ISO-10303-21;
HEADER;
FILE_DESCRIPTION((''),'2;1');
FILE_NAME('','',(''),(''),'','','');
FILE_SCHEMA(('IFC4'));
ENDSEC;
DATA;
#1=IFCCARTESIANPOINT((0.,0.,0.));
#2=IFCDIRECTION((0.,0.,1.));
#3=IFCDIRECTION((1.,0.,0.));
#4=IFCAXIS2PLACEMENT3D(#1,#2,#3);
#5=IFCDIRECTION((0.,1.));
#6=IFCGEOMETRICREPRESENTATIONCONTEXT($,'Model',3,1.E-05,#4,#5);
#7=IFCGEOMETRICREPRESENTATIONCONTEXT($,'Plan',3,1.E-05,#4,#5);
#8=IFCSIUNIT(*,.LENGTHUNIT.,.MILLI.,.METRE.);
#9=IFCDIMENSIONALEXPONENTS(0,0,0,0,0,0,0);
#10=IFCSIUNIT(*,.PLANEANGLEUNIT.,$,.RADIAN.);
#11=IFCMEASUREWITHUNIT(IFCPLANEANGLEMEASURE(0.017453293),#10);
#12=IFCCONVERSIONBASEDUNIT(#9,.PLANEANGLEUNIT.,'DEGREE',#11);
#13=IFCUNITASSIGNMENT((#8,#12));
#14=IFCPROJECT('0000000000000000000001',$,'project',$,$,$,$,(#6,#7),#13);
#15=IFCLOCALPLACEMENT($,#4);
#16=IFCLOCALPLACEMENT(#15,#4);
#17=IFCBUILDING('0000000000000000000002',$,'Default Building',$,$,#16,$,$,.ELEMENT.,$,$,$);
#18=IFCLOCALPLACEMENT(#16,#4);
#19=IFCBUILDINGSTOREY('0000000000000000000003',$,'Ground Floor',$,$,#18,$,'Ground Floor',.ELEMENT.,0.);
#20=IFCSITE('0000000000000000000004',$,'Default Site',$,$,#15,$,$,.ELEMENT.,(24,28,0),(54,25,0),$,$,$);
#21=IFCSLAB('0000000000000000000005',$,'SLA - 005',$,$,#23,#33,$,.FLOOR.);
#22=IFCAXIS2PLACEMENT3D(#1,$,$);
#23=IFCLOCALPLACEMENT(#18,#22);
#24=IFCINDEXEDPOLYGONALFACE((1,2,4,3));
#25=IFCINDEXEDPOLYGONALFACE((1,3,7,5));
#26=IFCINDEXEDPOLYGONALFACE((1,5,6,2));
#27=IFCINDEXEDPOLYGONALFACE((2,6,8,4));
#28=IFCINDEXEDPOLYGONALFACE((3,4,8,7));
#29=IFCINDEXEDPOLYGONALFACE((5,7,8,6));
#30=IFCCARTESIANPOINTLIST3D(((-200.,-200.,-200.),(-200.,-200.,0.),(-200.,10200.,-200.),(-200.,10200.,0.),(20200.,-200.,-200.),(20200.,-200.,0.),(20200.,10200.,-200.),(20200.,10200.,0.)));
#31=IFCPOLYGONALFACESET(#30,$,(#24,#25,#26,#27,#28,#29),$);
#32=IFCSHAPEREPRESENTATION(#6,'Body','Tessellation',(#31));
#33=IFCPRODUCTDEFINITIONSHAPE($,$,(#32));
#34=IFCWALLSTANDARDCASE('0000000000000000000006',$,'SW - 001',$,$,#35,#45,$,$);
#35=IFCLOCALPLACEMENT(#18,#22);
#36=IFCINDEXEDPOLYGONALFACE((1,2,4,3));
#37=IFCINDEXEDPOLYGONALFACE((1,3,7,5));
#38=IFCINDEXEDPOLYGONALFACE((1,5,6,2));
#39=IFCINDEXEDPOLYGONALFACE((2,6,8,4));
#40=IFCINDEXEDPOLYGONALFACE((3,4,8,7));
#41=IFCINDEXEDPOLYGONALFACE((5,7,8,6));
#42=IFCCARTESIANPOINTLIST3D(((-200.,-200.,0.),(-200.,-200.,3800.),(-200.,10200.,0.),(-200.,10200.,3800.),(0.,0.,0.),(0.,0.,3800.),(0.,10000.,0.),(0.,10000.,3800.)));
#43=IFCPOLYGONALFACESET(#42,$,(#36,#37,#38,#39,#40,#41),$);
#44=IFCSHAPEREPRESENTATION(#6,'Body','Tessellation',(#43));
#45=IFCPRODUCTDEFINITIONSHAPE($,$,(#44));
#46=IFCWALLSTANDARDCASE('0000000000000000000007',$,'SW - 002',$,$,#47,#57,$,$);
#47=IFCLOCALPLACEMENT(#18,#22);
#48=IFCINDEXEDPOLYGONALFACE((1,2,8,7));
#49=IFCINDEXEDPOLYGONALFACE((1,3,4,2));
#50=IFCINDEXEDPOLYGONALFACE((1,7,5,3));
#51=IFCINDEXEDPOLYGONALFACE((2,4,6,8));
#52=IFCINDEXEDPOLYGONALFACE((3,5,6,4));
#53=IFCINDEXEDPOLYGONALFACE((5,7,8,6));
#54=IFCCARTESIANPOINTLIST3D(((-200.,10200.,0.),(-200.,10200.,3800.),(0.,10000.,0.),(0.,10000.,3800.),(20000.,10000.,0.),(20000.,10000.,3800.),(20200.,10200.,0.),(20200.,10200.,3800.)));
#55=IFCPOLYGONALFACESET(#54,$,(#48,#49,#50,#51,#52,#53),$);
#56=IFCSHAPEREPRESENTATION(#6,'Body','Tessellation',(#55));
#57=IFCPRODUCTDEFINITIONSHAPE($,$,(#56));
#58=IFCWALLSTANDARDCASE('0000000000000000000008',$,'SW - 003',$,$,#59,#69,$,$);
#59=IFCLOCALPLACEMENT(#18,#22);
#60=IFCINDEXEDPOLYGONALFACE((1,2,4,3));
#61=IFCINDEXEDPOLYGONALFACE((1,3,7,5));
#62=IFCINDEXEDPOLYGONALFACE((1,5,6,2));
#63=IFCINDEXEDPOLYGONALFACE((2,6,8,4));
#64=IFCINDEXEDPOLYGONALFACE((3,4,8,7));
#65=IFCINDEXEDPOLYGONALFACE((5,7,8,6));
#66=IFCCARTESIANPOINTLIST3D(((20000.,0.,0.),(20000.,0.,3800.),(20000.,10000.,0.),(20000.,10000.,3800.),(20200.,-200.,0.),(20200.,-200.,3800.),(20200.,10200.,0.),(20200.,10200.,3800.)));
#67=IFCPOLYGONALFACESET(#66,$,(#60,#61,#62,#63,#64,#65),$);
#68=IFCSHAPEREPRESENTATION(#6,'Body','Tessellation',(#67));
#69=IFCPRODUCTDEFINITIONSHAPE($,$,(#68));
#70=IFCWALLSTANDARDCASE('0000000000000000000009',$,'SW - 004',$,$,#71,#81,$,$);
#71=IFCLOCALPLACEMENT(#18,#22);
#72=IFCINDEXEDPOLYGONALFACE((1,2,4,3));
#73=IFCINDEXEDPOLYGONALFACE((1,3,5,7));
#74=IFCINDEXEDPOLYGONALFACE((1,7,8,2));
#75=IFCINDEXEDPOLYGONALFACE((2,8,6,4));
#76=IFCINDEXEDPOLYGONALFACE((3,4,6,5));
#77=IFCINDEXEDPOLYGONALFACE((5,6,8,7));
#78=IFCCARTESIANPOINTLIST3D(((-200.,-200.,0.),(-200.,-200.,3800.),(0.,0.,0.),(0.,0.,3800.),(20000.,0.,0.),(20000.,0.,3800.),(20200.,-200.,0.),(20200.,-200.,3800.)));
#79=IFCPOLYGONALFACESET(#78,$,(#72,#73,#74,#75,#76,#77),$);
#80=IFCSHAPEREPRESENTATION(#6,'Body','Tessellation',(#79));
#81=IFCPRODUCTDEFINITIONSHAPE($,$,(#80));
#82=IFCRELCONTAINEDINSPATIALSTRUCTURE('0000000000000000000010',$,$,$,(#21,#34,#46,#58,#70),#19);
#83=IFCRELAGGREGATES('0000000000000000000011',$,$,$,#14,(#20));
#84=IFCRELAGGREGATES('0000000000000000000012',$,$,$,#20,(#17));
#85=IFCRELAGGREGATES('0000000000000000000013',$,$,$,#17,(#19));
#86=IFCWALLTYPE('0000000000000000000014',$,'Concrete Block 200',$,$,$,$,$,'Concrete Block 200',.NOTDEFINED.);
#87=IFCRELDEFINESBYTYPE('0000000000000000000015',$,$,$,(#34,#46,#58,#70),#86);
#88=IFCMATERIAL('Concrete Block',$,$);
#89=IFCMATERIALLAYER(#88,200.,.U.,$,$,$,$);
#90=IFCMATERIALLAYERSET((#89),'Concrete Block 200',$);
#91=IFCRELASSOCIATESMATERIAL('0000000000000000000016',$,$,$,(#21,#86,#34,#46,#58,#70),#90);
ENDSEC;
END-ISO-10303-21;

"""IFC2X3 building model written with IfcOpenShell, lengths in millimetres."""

from ifc_helpers import new_model, entity, si_unit, converted_unit, direction, frame, origin_with_axes, place, context, project, spatial, polyline, outline, extrude, material, layer, layer_set, layer_usage, type_object, element, save


model = new_model("IFC2X3")

# Units and contexts
model_context = context("Model", 3, precision=1e-05, world=origin_with_axes(), true_north=direction((0.0, 1.0)))
plan_context = context("Plan", 3, precision=1e-05, world=origin_with_axes(), true_north=direction((0.0, 1.0)))
ifc_project = project(units=[si_unit("LENGTHUNIT", "METRE", prefix="MILLI"), converted_unit("PLANEANGLEUNIT", "DEGREE", entity("IfcPlaneAngleMeasure", 0.017453293), si_unit("PLANEANGLEUNIT", "RADIAN"), dimensions=[0, 0, 0, 0, 0, 0, 0])], contexts=[model_context, plan_context])

# Site, building, storey
site_placement = place(None, origin_with_axes())
site = spatial("IfcSite", under=ifc_project, at=site_placement, Name="Default Site", CompositionType="ELEMENT", RefLatitude=(24, 28, 0), RefLongitude=(54, 25, 0))
building_placement = place(site_placement, origin_with_axes())
building = spatial("IfcBuilding", under=site, at=building_placement, Name="Default Building", CompositionType="ELEMENT")
storey_placement = place(building_placement, origin_with_axes())
storey = spatial("IfcBuildingStorey", under=building, at=storey_placement, Name="Ground Floor", LongName="Ground Floor", CompositionType="ELEMENT", Elevation=0.0)

# Slab
ifc_material = material(Name="Concrete Block")
ifc_layer = layer(ifc_material, 200.0, ventilated="UNKNOWN")
ifc_layer_set = layer_set([ifc_layer], Name="Concrete Block 200")
ifc_layer_usage_1 = layer_usage(ifc_layer_set, "AXIS3", "NEGATIVE", 200.0)
slab_placement = place(storey_placement, frame((-200.0, 10200.0, -200.0), z_axis=(0.0, 0.0, 1.0), x_axis=(1.0, 0.0, 0.0)))
element("IfcSlab", 1, at=slab_placement, inside=storey, material=ifc_layer_usage_1, Name="SLA - 005", PredefinedType="FLOOR", context=model_context, shape_type="SweptSolid", body=[
    extrude(outline(polyline([(0.0, 0.0), (20400.0, 0.0), (20400.0, -10400.0), (0.0, -10400.0), (0.0, 0.0)])), origin_with_axes(), (0.0, 0.0, 1.0), 200.0),
])

# Walls
ifc_layer_usage_2 = layer_usage(ifc_layer_set, "AXIS2", "POSITIVE", 0.0)
wall_type = type_object("IfcWallType", Name="Concrete Block 200", ElementType="Concrete Block 200", PredefinedType="NOTDEFINED", material=ifc_layer_set)
wall_1_placement = place(storey_placement, frame((0.0, 0.0, 0.0), z_axis=(0.0, 0.0, 1.0), x_axis=(0.0, 1.0, 0.0)))
element("IfcWallStandardCase", 2, at=wall_1_placement, inside=storey, type_object=wall_type, material=ifc_layer_usage_2, Name="SW - 001", context=model_context, shape_type="SweptSolid", body=[
    extrude(outline(polyline([(0.0, 0.0), (10000.0, 0.0), (10200.0, 200.0), (-200.0, 200.0), (0.0, 0.0)])), origin_with_axes(), (0.0, 0.0, 1.0), 3800.0),
])
ifc_layer_usage_3 = layer_usage(ifc_layer_set, "AXIS2", "POSITIVE", 0.0)
wall_2_placement = place(storey_placement, frame((0.0, 10000.0, 0.0), z_axis=(0.0, 0.0, 1.0), x_axis=(1.0, 0.0, 0.0)))
element("IfcWallStandardCase", 3, at=wall_2_placement, inside=storey, type_object=wall_type, material=ifc_layer_usage_3, Name="SW - 002", context=model_context, shape_type="SweptSolid", body=[
    extrude(outline(polyline([(0.0, 0.0), (20000.0, 0.0), (20200.0, 200.0), (-200.0, 200.0), (0.0, 0.0)])), origin_with_axes(), (0.0, 0.0, 1.0), 3800.0),
])
ifc_layer_usage_4 = layer_usage(ifc_layer_set, "AXIS2", "POSITIVE", 0.0)
wall_3_placement = place(storey_placement, frame((20000.0, 10000.0, 0.0), z_axis=(0.0, 0.0, 1.0), x_axis=(0.0, -1.0, 0.0)))
element("IfcWallStandardCase", 4, at=wall_3_placement, inside=storey, type_object=wall_type, material=ifc_layer_usage_4, Name="SW - 003", context=model_context, shape_type="SweptSolid", body=[
    extrude(outline(polyline([(0.0, 0.0), (10000.0, 0.0), (10200.0, 200.0), (-200.0, 200.0), (0.0, 0.0)])), origin_with_axes(), (0.0, 0.0, 1.0), 3800.0),
])
ifc_layer_usage_5 = layer_usage(ifc_layer_set, "AXIS2", "POSITIVE", 0.0)
wall_4_placement = place(storey_placement, frame((20000.0, 0.0, 0.0), z_axis=(0.0, 0.0, 1.0), x_axis=(-1.0, 0.0, 0.0)))
element("IfcWallStandardCase", 5, at=wall_4_placement, inside=storey, type_object=wall_type, material=ifc_layer_usage_5, Name="SW - 004", context=model_context, shape_type="SweptSolid", body=[
    extrude(outline(polyline([(0.0, 0.0), (20000.0, 0.0), (20200.0, 200.0), (-200.0, 200.0), (0.0, 0.0)])), origin_with_axes(), (0.0, 0.0, 1.0), 3800.0),
])

save(model, "model.ifc")
